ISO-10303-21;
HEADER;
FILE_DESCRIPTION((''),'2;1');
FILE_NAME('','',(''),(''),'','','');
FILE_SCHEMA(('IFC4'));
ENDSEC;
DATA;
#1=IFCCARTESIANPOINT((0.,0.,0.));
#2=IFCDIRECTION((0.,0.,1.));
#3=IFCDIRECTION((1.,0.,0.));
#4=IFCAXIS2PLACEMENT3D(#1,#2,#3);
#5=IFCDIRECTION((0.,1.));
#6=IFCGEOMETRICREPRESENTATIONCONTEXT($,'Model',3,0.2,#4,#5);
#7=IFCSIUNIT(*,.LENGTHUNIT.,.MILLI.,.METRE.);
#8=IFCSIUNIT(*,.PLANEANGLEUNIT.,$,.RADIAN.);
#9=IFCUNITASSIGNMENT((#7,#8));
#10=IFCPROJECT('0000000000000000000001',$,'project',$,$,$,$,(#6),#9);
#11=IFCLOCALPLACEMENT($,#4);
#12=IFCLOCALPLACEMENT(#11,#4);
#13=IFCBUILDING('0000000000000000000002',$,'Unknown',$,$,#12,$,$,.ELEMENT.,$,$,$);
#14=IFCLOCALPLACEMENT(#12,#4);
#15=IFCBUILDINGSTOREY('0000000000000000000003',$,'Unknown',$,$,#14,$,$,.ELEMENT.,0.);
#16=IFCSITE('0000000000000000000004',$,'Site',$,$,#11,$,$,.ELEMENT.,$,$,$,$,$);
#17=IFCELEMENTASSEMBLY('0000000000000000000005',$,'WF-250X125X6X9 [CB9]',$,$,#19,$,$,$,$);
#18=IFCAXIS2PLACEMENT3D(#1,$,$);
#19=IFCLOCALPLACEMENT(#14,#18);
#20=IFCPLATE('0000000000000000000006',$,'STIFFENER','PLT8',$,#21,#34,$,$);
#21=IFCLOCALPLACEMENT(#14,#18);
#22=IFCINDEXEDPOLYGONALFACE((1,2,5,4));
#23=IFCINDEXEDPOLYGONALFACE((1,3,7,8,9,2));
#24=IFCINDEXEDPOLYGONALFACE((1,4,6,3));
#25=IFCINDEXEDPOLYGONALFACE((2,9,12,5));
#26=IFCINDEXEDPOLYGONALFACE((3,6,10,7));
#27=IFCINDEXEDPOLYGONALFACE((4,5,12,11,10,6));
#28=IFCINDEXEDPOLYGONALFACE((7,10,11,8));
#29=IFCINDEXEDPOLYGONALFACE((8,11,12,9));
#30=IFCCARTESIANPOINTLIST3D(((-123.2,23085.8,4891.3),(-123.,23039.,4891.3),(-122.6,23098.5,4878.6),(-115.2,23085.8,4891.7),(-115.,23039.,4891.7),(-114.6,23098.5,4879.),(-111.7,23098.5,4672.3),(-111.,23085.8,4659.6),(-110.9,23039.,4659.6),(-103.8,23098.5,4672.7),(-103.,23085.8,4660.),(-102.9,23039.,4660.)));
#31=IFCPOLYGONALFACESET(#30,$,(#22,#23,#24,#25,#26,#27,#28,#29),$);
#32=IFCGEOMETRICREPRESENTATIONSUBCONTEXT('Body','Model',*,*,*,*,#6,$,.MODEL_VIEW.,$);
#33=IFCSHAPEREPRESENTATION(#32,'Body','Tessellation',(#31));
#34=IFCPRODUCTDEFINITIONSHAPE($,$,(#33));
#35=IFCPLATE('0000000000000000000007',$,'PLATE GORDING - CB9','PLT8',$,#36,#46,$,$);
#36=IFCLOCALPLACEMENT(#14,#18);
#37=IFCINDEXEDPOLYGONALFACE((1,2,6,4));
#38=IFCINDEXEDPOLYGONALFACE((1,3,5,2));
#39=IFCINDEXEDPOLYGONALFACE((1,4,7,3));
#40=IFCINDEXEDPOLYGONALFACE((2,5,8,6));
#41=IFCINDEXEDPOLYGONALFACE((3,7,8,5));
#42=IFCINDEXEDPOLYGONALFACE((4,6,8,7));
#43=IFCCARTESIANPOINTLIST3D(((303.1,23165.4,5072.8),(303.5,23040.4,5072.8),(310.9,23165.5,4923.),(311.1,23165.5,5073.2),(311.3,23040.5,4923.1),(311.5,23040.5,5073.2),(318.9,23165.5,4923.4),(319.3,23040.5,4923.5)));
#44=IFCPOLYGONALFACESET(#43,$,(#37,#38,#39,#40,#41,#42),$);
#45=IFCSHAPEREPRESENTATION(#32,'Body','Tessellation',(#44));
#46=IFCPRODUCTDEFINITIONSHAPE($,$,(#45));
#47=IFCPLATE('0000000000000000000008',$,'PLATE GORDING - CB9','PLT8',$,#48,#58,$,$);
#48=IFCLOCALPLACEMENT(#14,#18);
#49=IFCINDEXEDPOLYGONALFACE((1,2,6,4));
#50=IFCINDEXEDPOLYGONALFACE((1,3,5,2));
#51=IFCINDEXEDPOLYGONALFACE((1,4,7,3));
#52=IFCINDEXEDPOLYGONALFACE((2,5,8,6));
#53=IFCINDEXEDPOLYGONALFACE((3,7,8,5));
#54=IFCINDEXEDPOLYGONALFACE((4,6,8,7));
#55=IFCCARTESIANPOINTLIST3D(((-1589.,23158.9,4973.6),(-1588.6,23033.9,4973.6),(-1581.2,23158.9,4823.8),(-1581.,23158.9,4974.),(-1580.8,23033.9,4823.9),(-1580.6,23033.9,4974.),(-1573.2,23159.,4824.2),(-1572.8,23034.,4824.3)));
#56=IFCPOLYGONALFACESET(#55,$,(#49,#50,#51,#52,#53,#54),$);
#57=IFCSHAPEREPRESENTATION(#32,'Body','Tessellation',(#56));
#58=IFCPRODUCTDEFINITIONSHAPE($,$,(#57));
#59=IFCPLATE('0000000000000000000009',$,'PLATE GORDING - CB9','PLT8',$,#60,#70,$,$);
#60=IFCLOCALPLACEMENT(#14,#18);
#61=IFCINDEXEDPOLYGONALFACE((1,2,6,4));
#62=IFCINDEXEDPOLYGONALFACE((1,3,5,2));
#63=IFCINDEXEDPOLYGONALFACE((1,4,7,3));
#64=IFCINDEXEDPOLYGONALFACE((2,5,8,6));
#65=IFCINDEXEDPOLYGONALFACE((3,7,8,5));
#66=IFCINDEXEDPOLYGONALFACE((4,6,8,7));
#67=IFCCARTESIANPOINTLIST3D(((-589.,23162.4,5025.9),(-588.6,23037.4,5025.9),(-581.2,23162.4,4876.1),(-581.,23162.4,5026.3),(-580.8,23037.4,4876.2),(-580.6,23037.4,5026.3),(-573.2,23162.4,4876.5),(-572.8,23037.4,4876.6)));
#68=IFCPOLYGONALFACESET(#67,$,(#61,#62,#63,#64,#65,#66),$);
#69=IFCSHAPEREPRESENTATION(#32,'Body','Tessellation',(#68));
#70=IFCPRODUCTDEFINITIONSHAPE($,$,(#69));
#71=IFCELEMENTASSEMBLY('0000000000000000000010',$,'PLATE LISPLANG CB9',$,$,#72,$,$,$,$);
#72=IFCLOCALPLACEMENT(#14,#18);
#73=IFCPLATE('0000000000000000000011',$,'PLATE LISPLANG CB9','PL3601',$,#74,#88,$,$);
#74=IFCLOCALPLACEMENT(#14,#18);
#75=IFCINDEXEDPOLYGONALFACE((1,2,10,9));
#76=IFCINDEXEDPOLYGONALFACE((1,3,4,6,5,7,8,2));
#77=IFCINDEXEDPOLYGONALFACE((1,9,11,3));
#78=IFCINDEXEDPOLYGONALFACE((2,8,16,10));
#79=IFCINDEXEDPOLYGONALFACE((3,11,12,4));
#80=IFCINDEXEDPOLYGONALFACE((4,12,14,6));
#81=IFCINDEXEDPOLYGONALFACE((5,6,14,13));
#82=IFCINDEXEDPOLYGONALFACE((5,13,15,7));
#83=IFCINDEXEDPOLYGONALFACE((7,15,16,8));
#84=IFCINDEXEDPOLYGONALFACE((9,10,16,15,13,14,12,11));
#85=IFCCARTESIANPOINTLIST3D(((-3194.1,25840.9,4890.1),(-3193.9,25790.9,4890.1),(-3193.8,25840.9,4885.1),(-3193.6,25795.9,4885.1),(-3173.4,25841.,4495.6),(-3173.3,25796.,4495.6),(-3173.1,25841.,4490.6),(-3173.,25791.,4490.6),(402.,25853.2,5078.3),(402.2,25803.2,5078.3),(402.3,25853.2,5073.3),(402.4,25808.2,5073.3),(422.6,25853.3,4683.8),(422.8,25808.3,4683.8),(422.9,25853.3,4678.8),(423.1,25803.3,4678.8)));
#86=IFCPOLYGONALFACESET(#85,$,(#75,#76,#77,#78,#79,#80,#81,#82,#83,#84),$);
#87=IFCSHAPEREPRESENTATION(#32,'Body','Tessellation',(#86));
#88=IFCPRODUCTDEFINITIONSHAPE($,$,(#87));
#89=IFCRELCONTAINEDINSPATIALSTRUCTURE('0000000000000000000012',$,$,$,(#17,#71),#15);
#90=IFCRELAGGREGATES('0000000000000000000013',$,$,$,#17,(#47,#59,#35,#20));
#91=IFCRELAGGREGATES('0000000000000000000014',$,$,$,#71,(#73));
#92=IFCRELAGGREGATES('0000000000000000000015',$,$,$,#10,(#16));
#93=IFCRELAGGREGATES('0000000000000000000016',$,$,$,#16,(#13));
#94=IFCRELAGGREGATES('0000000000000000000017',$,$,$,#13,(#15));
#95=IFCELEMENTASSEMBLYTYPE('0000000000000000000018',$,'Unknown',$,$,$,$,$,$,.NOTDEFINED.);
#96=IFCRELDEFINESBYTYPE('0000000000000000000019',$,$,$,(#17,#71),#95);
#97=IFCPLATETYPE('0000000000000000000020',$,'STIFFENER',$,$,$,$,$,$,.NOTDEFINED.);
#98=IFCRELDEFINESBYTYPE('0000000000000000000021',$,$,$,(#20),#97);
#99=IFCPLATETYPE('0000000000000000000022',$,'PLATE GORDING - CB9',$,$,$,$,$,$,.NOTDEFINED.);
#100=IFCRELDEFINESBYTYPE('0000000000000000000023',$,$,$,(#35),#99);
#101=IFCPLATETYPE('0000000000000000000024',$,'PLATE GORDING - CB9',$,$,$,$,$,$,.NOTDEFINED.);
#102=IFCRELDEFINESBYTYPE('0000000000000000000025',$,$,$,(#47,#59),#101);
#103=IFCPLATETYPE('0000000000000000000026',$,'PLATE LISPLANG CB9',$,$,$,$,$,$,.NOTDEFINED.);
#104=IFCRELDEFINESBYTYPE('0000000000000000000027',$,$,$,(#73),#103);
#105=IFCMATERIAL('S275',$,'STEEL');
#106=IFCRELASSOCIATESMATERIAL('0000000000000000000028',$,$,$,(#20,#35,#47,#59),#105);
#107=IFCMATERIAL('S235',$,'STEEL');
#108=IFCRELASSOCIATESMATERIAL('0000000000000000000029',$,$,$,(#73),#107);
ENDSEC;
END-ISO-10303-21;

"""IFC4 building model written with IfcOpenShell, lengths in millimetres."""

from ifc_helpers import new_model, si_unit, direction, frame, origin_with_axes, place, context, subcontext, project, spatial, line, indexed_curve, outline, extrude, material, material_profile, profile_set, profile_usage, type_object, element, aggregate, save


model = new_model("IFC4")

# Units and contexts
model_context = context("Model", 3, precision=0.2, world=origin_with_axes(), true_north=direction((0.0, 1.0)))
body_context = subcontext(model_context, "Body", "Model", "MODEL_VIEW")
ifc_project = project(units=[si_unit("LENGTHUNIT", "METRE", prefix="MILLI"), si_unit("PLANEANGLEUNIT", "RADIAN")], contexts=[model_context])

# Site, building, storey
site_placement = place(None, origin_with_axes())
site = spatial("IfcSite", under=ifc_project, at=site_placement, Name="Site", CompositionType="ELEMENT")
building_placement = place(site_placement, origin_with_axes())
building = spatial("IfcBuilding", under=site, at=building_placement, Name="Unknown", CompositionType="ELEMENT")
storey_placement = place(building_placement, origin_with_axes())
storey = spatial("IfcBuildingStorey", under=building, at=storey_placement, Name="Unknown", CompositionType="ELEMENT", Elevation=0.0)

# Shared definitions
element_assembly_type = type_object("IfcElementAssemblyType", Name="Unknown", PredefinedType="NOTDEFINED")
ifc_material_1 = material(Name="S275", Category="STEEL")

# Element assembly
assembly_1_placement = place(storey_placement, frame((-2268.9, 23094.1, 4662.7), z_axis=(0.003456, -0.999994, 0.0), x_axis=(0.998624, 0.003452, 0.052336)))
assembly_1 = element("IfcElementAssembly", 1, at=assembly_1_placement, inside=storey, type_object=element_assembly_type, Name="WF-250X125X6X9 [CB9]")

# Plates
ifc_material_profile_1 = material_profile(ifc_material_1, outline(indexed_curve([(0.0, 0.0), (46.8, 0.0), (59.5, 12.7), (59.5, 219.3), (46.8, 232.0), (0.0, 232.0)], segments=[line(1, 2, 3, 4, 5, 6, 1)])), Name="PLT8")
ifc_profile_set_1 = profile_set([ifc_material_profile_1])
ifc_profile_usage_1 = profile_usage(ifc_profile_set_1, cardinal=2)
plate_type_1 = type_object("IfcPlateType", Name="STIFFENER", PredefinedType="NOTDEFINED")
plate_1_placement = place(assembly_1_placement, frame((2158.7, 116.0, 62.5), z_axis=(-1.0, 0.0, 0.0), x_axis=(0.0, 0.0, -1.0)))
plate_1 = element("IfcPlate", 2, at=plate_1_placement, type_object=plate_type_1, material=ifc_profile_usage_1, Name="STIFFENER", Description="PLT8", context=body_context, shape_type="SolidModel", body=[
    extrude(outline(indexed_curve([(0.0, 0.0), (46.8, 0.0), (59.5, 12.7), (59.5, 219.3), (46.8, 232.0), (0.0, 232.0)], segments=[line(1, 2, 3, 4, 5, 6, 1)])), frame((0.0, 0.0, 4.0), z_axis=(0.0, 0.0, 1.0), x_axis=(1.0, 0.0, 0.0)), (0.0, 0.0, -1.0), 8.0),
])
ifc_material_profile_2 = material_profile(ifc_material_1, outline(indexed_curve([(0.0, 0.0), (125.0, 0.0), (125.0, 149.9), (0.0, 150.0)], segments=[line(1, 2, 3, 4, 1)])), Name="PLT8")
ifc_profile_set_2 = profile_set([ifc_material_profile_2])
ifc_profile_usage_2 = profile_usage(ifc_profile_set_2, cardinal=5)
plate_type_2 = type_object("IfcPlateType", Name="PLATE GORDING - CB9", PredefinedType="NOTDEFINED")
plate_2_placement = place(assembly_1_placement, frame((2594.2, 274.9, -62.5), z_axis=(1.0, 0.0, 0.0), x_axis=(0.0, 0.0, 1.0)))
plate_2 = element("IfcPlate", 3, at=plate_2_placement, type_object=plate_type_2, material=ifc_profile_usage_2, Name="PLATE GORDING - CB9", Description="PLT8", context=body_context, shape_type="SolidModel", body=[
    extrude(outline(indexed_curve([(0.0, 0.0), (125.0, 0.0), (125.0, 149.9), (0.0, 150.0)], segments=[line(1, 2, 3, 4, 1)])), frame((0.0, 0.0, 4.0), z_axis=(0.0, 0.0, 1.0), x_axis=(1.0, 0.0, 0.0)), (0.0, 0.0, -1.0), 8.0),
])
ifc_material_profile_3 = material_profile(ifc_material_1, outline(indexed_curve([(0.0, 0.0), (149.9, 0.0), (150.0, 125.0), (0.0, 125.0)], segments=[line(1, 2, 3, 4, 1)])), Name="PLT8")
ifc_profile_set_3 = profile_set([ifc_material_profile_3])
ifc_profile_usage_3 = profile_usage(ifc_profile_set_3, cardinal=5)
plate_type_3 = type_object("IfcPlateType", Name="PLATE GORDING - CB9", PredefinedType="NOTDEFINED")
plate_3_placement = place(assembly_1_placement, frame((699.4, 274.9, 62.5), z_axis=(1.0, 0.0, 0.0), x_axis=(0.0, -1.0, 0.0)))
plate_3 = element("IfcPlate", 4, at=plate_3_placement, type_object=plate_type_3, material=ifc_profile_usage_3, Name="PLATE GORDING - CB9", Description="PLT8", context=body_context, shape_type="SolidModel", body=[
    extrude(outline(indexed_curve([(0.0, 0.0), (149.9, 0.0), (150.0, 125.0), (0.0, 125.0)], segments=[line(1, 2, 3, 4, 1)])), frame((0.0, 0.0, 4.0), z_axis=(0.0, 0.0, 1.0), x_axis=(1.0, 0.0, 0.0)), (0.0, 0.0, -1.0), 8.0),
])
plate_4_placement = place(assembly_1_placement, frame((1700.8, 274.8, 62.5), z_axis=(1.0, 0.0, 0.0), x_axis=(0.0, -1.0, 0.0)))
plate_4 = element("IfcPlate", 5, at=plate_4_placement, type_object=plate_type_3, material=ifc_profile_usage_3, Name="PLATE GORDING - CB9", Description="PLT8", context=body_context, shape_type="SolidModel", body=[
    extrude(outline(indexed_curve([(0.0, 0.0), (149.9, 0.0), (150.0, 125.0), (0.0, 125.0)], segments=[line(1, 2, 3, 4, 1)])), frame((0.0, 0.0, 4.0), z_axis=(0.0, 0.0, 1.0), x_axis=(1.0, 0.0, 0.0)), (0.0, 0.0, -1.0), 8.0),
])
aggregate(assembly_1, [plate_3, plate_4, plate_2, plate_1])

# Element assembly, plate
assembly_2_placement = place(storey_placement, frame((-1396.0, 25847.0, 4984.2), z_axis=(0.998627, 0.003432, 0.052264), x_axis=(0.00344, -0.999994, -0.000072)))
assembly_2 = element("IfcElementAssembly", 6, at=assembly_2_placement, inside=storey, type_object=element_assembly_type, Name="PLATE LISPLANG CB9")
ifc_material_2 = material(Name="S235", Category="STEEL")
ifc_material_profile_4 = material_profile(ifc_material_2, outline(indexed_curve([(0.0, 0.0), (50.0, 0.0), (50.0, 400.0), (0.0, 400.0), (0.0, 395.0), (45.0, 395.0), (45.0, 5.0), (0.0, 5.0)], segments=[line(1, 2, 3, 4, 5, 6, 7, 8, 1)])), Name="PL3601")
ifc_profile_set_4 = profile_set([ifc_material_profile_4])
ifc_profile_usage_4 = profile_usage(ifc_profile_set_4, cardinal=5)
plate_type_4 = type_object("IfcPlateType", Name="PLATE LISPLANG CB9", PredefinedType="NOTDEFINED")
plate_5_placement = place(assembly_2_placement, origin_with_axes())
plate_5 = element("IfcPlate", 7, at=plate_5_placement, type_object=plate_type_4, material=ifc_profile_usage_4, Name="PLATE LISPLANG CB9", Description="PL3601", context=body_context, shape_type="SolidModel", body=[
    extrude(outline(indexed_curve([(0.0, 0.0), (50.0, 0.0), (50.0, 400.0), (0.0, 400.0), (0.0, 395.0), (45.0, 395.0), (45.0, 5.0), (0.0, 5.0)], segments=[line(1, 2, 3, 4, 5, 6, 7, 8, 1)])), frame((0.0, 0.0, 1800.5), z_axis=(0.0, 0.0, 1.0), x_axis=(1.0, 0.0, 0.0)), (0.0, 0.0, -1.0), 3601.0),
])
aggregate(assembly_2, [plate_5])

save(model, "model.ifc")
